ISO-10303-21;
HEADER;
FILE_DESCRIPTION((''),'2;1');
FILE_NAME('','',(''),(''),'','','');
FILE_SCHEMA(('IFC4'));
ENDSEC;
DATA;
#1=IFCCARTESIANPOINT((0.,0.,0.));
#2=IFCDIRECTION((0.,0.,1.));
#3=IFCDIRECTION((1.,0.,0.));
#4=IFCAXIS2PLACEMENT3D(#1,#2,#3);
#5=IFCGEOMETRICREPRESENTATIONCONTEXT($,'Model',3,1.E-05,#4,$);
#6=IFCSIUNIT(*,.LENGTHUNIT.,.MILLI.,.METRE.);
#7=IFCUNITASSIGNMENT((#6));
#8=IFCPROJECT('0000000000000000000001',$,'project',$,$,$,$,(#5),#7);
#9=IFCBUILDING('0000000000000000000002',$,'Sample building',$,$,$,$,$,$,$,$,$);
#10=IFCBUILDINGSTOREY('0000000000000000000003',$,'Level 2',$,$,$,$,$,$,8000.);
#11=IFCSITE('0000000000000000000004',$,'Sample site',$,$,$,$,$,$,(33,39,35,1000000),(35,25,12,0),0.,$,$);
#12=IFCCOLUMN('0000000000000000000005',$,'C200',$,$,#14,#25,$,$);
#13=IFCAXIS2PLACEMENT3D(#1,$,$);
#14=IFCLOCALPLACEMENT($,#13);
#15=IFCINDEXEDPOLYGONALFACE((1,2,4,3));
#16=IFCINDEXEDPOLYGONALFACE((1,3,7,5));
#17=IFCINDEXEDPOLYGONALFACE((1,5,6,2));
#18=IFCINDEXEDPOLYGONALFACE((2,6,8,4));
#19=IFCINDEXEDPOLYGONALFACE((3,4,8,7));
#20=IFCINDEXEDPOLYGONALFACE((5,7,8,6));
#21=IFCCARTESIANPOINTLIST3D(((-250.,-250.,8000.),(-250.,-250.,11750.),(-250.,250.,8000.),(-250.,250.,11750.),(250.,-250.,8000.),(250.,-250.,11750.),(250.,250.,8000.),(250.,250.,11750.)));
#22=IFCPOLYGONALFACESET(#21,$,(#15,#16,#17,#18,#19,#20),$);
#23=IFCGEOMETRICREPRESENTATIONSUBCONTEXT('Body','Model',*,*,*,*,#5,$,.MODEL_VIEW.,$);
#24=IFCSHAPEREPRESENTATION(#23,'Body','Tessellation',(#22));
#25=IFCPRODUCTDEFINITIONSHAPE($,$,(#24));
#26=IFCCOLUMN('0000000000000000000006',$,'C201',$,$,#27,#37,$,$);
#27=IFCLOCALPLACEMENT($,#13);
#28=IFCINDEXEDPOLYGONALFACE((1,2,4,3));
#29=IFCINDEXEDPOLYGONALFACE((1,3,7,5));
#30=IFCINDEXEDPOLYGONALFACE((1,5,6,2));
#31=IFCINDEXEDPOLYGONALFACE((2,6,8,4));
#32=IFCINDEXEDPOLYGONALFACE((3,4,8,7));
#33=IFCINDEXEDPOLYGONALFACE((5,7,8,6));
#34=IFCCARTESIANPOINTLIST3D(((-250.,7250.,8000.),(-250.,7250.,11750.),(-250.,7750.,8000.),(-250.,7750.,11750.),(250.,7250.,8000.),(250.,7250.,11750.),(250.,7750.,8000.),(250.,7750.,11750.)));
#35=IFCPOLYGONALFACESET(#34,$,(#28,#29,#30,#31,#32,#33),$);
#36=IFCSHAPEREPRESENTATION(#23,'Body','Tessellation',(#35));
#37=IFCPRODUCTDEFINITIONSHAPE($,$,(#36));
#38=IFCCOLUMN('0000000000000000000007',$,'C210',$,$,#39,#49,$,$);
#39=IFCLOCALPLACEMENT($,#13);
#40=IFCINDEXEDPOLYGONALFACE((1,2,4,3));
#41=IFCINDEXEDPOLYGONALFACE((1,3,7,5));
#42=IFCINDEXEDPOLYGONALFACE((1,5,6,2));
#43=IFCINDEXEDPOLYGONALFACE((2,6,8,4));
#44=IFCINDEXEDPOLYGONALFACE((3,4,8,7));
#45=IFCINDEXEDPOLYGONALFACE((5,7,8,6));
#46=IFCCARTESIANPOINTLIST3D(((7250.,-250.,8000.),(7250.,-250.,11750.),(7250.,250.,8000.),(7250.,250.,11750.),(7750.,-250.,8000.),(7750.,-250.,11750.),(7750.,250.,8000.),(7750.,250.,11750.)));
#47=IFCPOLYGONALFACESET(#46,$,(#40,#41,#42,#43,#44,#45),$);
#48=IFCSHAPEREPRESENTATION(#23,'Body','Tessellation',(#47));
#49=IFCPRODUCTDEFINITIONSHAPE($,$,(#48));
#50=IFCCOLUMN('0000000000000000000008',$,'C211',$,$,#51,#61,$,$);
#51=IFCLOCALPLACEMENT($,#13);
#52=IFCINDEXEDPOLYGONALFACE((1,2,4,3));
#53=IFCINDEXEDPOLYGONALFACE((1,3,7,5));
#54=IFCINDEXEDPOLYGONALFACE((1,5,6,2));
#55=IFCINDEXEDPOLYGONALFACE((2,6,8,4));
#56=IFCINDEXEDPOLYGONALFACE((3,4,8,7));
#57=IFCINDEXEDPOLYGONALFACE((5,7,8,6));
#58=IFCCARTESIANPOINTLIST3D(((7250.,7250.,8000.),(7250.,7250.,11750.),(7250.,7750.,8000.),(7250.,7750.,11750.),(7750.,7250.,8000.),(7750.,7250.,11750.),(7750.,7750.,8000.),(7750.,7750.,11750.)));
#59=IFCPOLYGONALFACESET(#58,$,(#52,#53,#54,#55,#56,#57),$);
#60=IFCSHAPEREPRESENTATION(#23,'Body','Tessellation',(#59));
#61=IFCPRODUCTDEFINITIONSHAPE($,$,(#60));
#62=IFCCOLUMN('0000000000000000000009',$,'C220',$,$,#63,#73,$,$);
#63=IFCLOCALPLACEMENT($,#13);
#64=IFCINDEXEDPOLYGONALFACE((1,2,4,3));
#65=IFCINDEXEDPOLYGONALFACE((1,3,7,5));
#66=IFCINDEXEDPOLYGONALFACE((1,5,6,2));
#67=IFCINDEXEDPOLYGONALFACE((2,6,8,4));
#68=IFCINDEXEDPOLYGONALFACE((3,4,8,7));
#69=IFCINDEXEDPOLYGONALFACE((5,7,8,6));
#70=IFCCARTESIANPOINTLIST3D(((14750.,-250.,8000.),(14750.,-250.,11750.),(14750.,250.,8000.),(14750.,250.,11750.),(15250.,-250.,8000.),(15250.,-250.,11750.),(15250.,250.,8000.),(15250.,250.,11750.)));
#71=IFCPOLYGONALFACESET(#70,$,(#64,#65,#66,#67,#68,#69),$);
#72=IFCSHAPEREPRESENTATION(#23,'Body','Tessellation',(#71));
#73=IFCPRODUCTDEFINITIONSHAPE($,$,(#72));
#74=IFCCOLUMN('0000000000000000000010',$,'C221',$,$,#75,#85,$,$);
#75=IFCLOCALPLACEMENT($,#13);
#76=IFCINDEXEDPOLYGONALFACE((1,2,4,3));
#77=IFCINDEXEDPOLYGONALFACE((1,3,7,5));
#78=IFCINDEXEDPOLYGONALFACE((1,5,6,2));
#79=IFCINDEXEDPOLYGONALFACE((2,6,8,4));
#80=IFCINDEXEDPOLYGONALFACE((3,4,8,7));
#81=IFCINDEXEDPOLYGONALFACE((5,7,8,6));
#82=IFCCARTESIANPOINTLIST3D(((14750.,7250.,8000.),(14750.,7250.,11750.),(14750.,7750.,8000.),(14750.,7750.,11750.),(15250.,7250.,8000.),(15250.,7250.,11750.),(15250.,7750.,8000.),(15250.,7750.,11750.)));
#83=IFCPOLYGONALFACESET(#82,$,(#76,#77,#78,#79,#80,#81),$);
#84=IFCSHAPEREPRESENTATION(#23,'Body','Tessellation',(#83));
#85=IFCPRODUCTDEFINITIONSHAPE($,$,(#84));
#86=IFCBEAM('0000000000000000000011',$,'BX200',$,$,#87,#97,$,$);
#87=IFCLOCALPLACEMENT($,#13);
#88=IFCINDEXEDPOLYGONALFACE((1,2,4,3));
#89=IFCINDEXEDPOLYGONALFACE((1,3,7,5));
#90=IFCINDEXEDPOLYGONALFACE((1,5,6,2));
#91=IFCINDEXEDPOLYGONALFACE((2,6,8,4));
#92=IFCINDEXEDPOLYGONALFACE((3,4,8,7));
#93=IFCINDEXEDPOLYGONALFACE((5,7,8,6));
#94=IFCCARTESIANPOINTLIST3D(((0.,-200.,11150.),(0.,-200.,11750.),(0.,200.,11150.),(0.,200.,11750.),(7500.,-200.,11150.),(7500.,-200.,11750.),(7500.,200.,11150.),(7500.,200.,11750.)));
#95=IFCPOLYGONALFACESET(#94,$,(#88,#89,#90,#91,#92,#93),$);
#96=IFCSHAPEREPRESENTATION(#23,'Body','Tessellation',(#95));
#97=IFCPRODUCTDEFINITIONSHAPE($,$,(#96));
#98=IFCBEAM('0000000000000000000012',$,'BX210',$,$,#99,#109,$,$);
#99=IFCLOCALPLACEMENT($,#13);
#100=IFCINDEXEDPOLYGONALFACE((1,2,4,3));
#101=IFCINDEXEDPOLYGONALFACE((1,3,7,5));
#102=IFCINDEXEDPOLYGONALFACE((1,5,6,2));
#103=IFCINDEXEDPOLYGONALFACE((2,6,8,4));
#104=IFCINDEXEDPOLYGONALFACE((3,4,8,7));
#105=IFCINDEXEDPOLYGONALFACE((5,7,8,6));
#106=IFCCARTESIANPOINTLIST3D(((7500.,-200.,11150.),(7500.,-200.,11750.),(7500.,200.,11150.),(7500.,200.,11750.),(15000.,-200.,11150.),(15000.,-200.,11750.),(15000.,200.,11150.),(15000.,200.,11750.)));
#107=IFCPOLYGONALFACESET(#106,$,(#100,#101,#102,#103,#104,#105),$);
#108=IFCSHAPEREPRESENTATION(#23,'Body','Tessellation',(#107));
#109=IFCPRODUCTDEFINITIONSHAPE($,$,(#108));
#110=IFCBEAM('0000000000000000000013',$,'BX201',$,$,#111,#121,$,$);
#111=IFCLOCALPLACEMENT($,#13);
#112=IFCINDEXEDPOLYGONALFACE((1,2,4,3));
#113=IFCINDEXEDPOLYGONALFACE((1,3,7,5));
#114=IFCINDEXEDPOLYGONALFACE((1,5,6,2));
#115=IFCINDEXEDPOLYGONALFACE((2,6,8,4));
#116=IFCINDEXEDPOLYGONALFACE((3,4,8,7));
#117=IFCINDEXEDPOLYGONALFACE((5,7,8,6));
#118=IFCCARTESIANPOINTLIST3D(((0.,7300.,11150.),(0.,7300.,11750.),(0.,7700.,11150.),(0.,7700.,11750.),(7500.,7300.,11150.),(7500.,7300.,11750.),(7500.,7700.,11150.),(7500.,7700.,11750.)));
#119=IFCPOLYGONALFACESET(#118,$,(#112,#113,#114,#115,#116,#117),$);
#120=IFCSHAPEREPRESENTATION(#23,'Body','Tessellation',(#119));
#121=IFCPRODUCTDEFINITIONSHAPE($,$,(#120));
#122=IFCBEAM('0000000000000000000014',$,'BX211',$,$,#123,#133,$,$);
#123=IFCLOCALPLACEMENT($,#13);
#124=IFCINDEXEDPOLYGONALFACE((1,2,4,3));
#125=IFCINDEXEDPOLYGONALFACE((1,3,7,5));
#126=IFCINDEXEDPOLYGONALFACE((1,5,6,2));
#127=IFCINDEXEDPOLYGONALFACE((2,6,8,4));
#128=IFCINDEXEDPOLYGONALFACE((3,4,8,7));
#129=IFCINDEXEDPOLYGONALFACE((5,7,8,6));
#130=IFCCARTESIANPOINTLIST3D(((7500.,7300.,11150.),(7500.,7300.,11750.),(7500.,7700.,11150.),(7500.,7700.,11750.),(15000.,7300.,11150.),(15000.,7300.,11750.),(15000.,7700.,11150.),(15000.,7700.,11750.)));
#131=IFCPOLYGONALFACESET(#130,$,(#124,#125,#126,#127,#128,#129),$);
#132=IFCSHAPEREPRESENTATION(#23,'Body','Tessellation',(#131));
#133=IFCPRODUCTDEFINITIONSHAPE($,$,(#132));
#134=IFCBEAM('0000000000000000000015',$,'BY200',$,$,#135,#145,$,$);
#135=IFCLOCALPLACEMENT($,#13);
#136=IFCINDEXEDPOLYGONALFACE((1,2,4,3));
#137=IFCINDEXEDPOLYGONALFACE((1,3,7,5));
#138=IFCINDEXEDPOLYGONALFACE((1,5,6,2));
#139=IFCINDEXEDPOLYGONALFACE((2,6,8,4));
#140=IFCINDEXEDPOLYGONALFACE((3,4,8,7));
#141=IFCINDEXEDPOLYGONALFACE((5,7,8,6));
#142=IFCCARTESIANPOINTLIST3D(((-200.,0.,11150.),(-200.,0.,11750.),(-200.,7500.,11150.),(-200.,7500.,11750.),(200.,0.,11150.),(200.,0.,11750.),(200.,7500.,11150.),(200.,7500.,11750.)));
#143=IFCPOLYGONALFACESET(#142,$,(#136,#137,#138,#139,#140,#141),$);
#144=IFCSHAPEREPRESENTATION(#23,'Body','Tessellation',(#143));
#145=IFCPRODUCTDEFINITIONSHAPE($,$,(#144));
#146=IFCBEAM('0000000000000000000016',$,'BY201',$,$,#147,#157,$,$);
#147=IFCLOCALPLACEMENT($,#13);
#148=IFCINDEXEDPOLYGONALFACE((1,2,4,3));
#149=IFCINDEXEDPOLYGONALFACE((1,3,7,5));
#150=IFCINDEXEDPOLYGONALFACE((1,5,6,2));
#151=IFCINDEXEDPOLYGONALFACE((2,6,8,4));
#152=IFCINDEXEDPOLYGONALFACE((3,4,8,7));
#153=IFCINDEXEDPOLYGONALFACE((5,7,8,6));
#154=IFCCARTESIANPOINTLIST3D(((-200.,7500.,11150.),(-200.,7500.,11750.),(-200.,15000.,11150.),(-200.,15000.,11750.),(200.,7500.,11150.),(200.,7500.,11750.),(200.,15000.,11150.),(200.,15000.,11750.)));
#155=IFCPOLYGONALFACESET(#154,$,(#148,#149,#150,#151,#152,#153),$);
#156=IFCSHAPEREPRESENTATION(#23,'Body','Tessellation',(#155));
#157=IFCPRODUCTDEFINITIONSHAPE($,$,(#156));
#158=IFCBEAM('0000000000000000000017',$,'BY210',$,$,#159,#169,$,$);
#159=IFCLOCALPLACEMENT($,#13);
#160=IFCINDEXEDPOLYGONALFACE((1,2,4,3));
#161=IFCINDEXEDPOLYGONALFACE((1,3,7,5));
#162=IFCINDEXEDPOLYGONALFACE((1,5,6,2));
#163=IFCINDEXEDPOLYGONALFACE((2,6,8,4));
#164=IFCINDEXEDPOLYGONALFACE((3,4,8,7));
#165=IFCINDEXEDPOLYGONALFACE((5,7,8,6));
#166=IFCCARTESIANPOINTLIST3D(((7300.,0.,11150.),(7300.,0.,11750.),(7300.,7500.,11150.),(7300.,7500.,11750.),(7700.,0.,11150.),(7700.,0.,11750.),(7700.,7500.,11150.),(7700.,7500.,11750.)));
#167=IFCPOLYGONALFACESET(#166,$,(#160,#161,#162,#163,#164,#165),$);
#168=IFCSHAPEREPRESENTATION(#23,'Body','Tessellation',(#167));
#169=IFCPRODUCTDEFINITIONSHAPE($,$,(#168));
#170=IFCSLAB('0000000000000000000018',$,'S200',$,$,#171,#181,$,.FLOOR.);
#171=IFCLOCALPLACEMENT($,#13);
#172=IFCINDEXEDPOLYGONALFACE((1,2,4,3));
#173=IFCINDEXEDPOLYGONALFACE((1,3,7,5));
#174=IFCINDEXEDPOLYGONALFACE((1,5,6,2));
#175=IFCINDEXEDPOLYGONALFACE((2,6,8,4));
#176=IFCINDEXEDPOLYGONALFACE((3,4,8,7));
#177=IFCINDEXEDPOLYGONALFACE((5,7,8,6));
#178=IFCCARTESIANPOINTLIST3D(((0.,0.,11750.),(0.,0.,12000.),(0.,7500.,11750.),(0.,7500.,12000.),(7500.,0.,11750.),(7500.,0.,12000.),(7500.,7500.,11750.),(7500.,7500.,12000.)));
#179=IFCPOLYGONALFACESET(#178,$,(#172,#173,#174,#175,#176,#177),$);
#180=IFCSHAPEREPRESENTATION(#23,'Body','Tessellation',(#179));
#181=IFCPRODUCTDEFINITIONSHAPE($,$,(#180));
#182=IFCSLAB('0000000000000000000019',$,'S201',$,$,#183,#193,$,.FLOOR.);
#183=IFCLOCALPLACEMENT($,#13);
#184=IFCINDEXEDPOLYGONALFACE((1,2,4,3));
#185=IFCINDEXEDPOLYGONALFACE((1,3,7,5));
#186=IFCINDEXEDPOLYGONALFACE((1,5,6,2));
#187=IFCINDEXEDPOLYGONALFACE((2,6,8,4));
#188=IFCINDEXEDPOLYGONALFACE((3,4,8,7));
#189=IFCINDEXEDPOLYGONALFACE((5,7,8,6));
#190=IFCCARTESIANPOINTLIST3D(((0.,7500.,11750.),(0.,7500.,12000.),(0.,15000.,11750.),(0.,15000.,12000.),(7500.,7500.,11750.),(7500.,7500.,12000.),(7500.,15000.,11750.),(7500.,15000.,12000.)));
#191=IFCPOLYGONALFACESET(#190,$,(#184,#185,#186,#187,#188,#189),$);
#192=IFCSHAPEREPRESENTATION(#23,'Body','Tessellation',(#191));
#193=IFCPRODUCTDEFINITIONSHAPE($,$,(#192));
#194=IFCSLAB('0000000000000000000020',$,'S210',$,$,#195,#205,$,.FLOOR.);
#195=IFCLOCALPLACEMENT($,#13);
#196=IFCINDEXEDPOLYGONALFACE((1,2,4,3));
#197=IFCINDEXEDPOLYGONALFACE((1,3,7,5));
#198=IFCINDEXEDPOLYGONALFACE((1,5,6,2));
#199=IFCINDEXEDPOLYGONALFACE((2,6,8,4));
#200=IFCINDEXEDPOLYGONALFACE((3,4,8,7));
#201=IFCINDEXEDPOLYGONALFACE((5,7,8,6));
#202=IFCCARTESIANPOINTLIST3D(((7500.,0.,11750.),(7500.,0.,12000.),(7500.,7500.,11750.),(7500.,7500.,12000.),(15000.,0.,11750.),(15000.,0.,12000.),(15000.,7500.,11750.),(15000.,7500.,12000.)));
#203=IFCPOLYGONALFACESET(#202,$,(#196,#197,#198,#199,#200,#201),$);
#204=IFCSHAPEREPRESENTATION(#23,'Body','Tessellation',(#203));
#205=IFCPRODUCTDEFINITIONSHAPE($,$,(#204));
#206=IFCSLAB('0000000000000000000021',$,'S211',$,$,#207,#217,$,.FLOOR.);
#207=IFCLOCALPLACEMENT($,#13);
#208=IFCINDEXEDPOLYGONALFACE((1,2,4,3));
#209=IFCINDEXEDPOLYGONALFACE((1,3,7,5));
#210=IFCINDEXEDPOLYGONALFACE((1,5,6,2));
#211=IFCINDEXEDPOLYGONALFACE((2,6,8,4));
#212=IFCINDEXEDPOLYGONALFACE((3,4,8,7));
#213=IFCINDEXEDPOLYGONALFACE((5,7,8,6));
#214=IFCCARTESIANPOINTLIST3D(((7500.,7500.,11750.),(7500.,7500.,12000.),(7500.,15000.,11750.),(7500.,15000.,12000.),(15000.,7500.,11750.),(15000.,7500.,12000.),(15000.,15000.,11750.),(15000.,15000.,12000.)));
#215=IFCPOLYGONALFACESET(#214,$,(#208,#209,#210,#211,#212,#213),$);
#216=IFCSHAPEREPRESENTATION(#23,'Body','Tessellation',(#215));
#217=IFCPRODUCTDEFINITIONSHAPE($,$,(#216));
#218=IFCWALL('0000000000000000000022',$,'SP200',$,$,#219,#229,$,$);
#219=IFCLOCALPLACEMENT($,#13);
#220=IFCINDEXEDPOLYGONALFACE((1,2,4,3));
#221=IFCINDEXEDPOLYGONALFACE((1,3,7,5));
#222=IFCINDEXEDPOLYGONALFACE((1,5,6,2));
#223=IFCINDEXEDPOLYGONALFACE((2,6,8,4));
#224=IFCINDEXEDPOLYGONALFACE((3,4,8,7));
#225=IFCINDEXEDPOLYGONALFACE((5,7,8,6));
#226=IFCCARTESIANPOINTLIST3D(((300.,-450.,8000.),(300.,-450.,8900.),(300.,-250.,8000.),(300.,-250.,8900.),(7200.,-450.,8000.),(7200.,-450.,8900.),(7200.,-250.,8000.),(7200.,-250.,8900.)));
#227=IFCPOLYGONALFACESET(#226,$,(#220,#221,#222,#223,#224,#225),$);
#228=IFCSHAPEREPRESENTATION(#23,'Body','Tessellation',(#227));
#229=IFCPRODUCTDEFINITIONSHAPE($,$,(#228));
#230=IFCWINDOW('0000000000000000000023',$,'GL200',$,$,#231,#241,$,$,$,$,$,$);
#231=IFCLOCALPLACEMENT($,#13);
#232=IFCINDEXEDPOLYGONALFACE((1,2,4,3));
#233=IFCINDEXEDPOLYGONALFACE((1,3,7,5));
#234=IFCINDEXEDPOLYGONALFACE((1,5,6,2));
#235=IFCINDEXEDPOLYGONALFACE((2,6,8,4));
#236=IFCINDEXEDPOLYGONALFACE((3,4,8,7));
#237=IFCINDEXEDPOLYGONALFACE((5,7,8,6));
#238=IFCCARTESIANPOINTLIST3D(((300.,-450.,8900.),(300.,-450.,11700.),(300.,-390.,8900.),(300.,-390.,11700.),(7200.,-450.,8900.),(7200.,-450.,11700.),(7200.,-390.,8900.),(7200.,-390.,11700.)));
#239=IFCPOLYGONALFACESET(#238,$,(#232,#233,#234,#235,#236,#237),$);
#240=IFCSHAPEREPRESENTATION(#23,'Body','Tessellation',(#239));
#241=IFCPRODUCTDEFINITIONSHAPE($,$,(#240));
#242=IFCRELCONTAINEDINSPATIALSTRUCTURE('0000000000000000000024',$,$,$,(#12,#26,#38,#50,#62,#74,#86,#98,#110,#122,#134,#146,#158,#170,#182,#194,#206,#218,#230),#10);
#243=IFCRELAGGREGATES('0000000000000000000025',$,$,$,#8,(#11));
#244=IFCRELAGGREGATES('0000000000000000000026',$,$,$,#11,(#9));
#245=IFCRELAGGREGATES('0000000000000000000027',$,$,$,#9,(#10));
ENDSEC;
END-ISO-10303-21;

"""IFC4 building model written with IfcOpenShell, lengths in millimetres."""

from ifc_helpers import new_model, si_unit, frame, origin_with_axes, place, context, subcontext, project, spatial, indexed_curve, outline, extrude, element, save


model = new_model("IFC4")

# Units and contexts
model_context = context("Model", 3, precision=1e-05, world=origin_with_axes())
body_context = subcontext(model_context, "Body", "Model", "MODEL_VIEW")
ifc_project = project(units=[si_unit("LENGTHUNIT", "METRE", prefix="MILLI")], contexts=[model_context])

# Site, building, storey
site = spatial("IfcSite", under=ifc_project, Name="Sample site", RefLatitude=(33, 39, 35, 1000000), RefLongitude=(35, 25, 12, 0), RefElevation=0.0)
building = spatial("IfcBuilding", under=site, Name="Sample building")
storey = spatial("IfcBuildingStorey", under=building, Name="Level 2", Elevation=8000.0)

# Columns
for number, where, z_axis, x_axis, name in (
    (1, (-250.0, -250.0, 8000.0), (0.0, 0.0, 1.0), (1.0, 0.0, 0.0), "C200"),
    (2, (-250.0, 7250.0, 8000.0), (0.0, 0.0, 1.0), (1.0, 0.0, 0.0), "C201"),
    (3, (7250.0, -250.0, 8000.0), (0.0, 0.0, 1.0), (1.0, 0.0, 0.0), "C210"),
    (4, (7250.0, 7250.0, 8000.0), (0.0, 0.0, 1.0), (1.0, 0.0, 0.0), "C211"),
    (5, (14750.0, -250.0, 8000.0), (0.0, 0.0, 1.0), (1.0, 0.0, 0.0), "C220"),
    (6, (14750.0, 7250.0, 8000.0), (0.0, 0.0, 1.0), (1.0, 0.0, 0.0), "C221"),
):
    element("IfcColumn", number, at=place(None, frame(where, z_axis=z_axis, x_axis=x_axis)), inside=storey, Name=name, context=body_context, shape_type="SweptSolid", body=[
        extrude(outline(indexed_curve([(0.0, 0.0), (0.0, 500.0), (500.0, 500.0), (500.0, 0.0), (0.0, 0.0)], self_intersect=False)), origin_with_axes(), (0.0, 0.0, 1.0), 3750.0),
    ])

# Beams
for number, where, z_axis, x_axis, name in (
    (7, (0.0, -200.0, 11150.0), (0.0, 0.0, 1.0), (1.0, 0.0, 0.0), "BX200"),
    (8, (7500.0, -200.0, 11150.0), (0.0, 0.0, 1.0), (1.0, 0.0, 0.0), "BX210"),
    (9, (0.0, 7300.0, 11150.0), (0.0, 0.0, 1.0), (1.0, 0.0, 0.0), "BX201"),
    (10, (7500.0, 7300.0, 11150.0), (0.0, 0.0, 1.0), (1.0, 0.0, 0.0), "BX211"),
    (11, (200.0, 0.0, 11150.0), (0.0, 0.0, 1.0), (0.0, 1.0, 0.0), "BY200"),
    (12, (200.0, 7500.0, 11150.0), (0.0, 0.0, 1.0), (0.0, 1.0, 0.0), "BY201"),
    (13, (7700.0, 0.0, 11150.0), (0.0, 0.0, 1.0), (0.0, 1.0, 0.0), "BY210"),
):
    element("IfcBeam", number, at=place(None, frame(where, z_axis=z_axis, x_axis=x_axis)), inside=storey, Name=name, context=body_context, shape_type="SweptSolid", body=[
        extrude(outline(indexed_curve([(0.0, 0.0), (0.0, 400.0), (7500.0, 400.0), (7500.0, 0.0), (0.0, 0.0)], self_intersect=False)), origin_with_axes(), (0.0, 0.0, 1.0), 600.0),
    ])

# Slabs
for number, where, z_axis, x_axis, name in (
    (14, (0.0, 0.0, 11750.0), (0.0, 0.0, 1.0), (1.0, 0.0, 0.0), "S200"),
    (15, (0.0, 7500.0, 11750.0), (0.0, 0.0, 1.0), (1.0, 0.0, 0.0), "S201"),
    (16, (7500.0, 0.0, 11750.0), (0.0, 0.0, 1.0), (1.0, 0.0, 0.0), "S210"),
    (17, (7500.0, 7500.0, 11750.0), (0.0, 0.0, 1.0), (1.0, 0.0, 0.0), "S211"),
):
    element("IfcSlab", number, at=place(None, frame(where, z_axis=z_axis, x_axis=x_axis)), inside=storey, Name=name, PredefinedType="FLOOR", context=body_context, shape_type="SweptSolid", body=[
        extrude(outline(indexed_curve([(0.0, 0.0), (0.0, 7500.0), (7500.0, 7500.0), (7500.0, 0.0), (0.0, 0.0)], self_intersect=False)), origin_with_axes(), (0.0, 0.0, 1.0), 250.0),
    ])

# Wall
wall_1_placement = place(None, frame((300.0, -450.0, 8000.0), z_axis=(0.0, 0.0, 1.0), x_axis=(1.0, 0.0, 0.0)))
element("IfcWall", 18, at=wall_1_placement, inside=storey, Name="SP200", context=body_context, shape_type="SweptSolid", body=[
    extrude(outline(indexed_curve([(0.0, 0.0), (0.0, 200.0), (6900.0, 200.0), (6900.0, 0.0), (0.0, 0.0)], self_intersect=False)), origin_with_axes(), (0.0, 0.0, 1.0), 900.0),
])

# Window
window_1_placement = place(None, frame((300.0, -450.0, 8900.0), z_axis=(0.0, 0.0, 1.0), x_axis=(1.0, 0.0, 0.0)))
element("IfcWindow", 19, at=window_1_placement, inside=storey, Name="GL200", context=body_context, shape_type="SweptSolid", body=[
    extrude(outline(indexed_curve([(0.0, 0.0), (0.0, 60.0), (6900.0, 60.0), (6900.0, 0.0), (0.0, 0.0)], self_intersect=False)), origin_with_axes(), (0.0, 0.0, 1.0), 2800.0),
])

save(model, "model.ifc")
